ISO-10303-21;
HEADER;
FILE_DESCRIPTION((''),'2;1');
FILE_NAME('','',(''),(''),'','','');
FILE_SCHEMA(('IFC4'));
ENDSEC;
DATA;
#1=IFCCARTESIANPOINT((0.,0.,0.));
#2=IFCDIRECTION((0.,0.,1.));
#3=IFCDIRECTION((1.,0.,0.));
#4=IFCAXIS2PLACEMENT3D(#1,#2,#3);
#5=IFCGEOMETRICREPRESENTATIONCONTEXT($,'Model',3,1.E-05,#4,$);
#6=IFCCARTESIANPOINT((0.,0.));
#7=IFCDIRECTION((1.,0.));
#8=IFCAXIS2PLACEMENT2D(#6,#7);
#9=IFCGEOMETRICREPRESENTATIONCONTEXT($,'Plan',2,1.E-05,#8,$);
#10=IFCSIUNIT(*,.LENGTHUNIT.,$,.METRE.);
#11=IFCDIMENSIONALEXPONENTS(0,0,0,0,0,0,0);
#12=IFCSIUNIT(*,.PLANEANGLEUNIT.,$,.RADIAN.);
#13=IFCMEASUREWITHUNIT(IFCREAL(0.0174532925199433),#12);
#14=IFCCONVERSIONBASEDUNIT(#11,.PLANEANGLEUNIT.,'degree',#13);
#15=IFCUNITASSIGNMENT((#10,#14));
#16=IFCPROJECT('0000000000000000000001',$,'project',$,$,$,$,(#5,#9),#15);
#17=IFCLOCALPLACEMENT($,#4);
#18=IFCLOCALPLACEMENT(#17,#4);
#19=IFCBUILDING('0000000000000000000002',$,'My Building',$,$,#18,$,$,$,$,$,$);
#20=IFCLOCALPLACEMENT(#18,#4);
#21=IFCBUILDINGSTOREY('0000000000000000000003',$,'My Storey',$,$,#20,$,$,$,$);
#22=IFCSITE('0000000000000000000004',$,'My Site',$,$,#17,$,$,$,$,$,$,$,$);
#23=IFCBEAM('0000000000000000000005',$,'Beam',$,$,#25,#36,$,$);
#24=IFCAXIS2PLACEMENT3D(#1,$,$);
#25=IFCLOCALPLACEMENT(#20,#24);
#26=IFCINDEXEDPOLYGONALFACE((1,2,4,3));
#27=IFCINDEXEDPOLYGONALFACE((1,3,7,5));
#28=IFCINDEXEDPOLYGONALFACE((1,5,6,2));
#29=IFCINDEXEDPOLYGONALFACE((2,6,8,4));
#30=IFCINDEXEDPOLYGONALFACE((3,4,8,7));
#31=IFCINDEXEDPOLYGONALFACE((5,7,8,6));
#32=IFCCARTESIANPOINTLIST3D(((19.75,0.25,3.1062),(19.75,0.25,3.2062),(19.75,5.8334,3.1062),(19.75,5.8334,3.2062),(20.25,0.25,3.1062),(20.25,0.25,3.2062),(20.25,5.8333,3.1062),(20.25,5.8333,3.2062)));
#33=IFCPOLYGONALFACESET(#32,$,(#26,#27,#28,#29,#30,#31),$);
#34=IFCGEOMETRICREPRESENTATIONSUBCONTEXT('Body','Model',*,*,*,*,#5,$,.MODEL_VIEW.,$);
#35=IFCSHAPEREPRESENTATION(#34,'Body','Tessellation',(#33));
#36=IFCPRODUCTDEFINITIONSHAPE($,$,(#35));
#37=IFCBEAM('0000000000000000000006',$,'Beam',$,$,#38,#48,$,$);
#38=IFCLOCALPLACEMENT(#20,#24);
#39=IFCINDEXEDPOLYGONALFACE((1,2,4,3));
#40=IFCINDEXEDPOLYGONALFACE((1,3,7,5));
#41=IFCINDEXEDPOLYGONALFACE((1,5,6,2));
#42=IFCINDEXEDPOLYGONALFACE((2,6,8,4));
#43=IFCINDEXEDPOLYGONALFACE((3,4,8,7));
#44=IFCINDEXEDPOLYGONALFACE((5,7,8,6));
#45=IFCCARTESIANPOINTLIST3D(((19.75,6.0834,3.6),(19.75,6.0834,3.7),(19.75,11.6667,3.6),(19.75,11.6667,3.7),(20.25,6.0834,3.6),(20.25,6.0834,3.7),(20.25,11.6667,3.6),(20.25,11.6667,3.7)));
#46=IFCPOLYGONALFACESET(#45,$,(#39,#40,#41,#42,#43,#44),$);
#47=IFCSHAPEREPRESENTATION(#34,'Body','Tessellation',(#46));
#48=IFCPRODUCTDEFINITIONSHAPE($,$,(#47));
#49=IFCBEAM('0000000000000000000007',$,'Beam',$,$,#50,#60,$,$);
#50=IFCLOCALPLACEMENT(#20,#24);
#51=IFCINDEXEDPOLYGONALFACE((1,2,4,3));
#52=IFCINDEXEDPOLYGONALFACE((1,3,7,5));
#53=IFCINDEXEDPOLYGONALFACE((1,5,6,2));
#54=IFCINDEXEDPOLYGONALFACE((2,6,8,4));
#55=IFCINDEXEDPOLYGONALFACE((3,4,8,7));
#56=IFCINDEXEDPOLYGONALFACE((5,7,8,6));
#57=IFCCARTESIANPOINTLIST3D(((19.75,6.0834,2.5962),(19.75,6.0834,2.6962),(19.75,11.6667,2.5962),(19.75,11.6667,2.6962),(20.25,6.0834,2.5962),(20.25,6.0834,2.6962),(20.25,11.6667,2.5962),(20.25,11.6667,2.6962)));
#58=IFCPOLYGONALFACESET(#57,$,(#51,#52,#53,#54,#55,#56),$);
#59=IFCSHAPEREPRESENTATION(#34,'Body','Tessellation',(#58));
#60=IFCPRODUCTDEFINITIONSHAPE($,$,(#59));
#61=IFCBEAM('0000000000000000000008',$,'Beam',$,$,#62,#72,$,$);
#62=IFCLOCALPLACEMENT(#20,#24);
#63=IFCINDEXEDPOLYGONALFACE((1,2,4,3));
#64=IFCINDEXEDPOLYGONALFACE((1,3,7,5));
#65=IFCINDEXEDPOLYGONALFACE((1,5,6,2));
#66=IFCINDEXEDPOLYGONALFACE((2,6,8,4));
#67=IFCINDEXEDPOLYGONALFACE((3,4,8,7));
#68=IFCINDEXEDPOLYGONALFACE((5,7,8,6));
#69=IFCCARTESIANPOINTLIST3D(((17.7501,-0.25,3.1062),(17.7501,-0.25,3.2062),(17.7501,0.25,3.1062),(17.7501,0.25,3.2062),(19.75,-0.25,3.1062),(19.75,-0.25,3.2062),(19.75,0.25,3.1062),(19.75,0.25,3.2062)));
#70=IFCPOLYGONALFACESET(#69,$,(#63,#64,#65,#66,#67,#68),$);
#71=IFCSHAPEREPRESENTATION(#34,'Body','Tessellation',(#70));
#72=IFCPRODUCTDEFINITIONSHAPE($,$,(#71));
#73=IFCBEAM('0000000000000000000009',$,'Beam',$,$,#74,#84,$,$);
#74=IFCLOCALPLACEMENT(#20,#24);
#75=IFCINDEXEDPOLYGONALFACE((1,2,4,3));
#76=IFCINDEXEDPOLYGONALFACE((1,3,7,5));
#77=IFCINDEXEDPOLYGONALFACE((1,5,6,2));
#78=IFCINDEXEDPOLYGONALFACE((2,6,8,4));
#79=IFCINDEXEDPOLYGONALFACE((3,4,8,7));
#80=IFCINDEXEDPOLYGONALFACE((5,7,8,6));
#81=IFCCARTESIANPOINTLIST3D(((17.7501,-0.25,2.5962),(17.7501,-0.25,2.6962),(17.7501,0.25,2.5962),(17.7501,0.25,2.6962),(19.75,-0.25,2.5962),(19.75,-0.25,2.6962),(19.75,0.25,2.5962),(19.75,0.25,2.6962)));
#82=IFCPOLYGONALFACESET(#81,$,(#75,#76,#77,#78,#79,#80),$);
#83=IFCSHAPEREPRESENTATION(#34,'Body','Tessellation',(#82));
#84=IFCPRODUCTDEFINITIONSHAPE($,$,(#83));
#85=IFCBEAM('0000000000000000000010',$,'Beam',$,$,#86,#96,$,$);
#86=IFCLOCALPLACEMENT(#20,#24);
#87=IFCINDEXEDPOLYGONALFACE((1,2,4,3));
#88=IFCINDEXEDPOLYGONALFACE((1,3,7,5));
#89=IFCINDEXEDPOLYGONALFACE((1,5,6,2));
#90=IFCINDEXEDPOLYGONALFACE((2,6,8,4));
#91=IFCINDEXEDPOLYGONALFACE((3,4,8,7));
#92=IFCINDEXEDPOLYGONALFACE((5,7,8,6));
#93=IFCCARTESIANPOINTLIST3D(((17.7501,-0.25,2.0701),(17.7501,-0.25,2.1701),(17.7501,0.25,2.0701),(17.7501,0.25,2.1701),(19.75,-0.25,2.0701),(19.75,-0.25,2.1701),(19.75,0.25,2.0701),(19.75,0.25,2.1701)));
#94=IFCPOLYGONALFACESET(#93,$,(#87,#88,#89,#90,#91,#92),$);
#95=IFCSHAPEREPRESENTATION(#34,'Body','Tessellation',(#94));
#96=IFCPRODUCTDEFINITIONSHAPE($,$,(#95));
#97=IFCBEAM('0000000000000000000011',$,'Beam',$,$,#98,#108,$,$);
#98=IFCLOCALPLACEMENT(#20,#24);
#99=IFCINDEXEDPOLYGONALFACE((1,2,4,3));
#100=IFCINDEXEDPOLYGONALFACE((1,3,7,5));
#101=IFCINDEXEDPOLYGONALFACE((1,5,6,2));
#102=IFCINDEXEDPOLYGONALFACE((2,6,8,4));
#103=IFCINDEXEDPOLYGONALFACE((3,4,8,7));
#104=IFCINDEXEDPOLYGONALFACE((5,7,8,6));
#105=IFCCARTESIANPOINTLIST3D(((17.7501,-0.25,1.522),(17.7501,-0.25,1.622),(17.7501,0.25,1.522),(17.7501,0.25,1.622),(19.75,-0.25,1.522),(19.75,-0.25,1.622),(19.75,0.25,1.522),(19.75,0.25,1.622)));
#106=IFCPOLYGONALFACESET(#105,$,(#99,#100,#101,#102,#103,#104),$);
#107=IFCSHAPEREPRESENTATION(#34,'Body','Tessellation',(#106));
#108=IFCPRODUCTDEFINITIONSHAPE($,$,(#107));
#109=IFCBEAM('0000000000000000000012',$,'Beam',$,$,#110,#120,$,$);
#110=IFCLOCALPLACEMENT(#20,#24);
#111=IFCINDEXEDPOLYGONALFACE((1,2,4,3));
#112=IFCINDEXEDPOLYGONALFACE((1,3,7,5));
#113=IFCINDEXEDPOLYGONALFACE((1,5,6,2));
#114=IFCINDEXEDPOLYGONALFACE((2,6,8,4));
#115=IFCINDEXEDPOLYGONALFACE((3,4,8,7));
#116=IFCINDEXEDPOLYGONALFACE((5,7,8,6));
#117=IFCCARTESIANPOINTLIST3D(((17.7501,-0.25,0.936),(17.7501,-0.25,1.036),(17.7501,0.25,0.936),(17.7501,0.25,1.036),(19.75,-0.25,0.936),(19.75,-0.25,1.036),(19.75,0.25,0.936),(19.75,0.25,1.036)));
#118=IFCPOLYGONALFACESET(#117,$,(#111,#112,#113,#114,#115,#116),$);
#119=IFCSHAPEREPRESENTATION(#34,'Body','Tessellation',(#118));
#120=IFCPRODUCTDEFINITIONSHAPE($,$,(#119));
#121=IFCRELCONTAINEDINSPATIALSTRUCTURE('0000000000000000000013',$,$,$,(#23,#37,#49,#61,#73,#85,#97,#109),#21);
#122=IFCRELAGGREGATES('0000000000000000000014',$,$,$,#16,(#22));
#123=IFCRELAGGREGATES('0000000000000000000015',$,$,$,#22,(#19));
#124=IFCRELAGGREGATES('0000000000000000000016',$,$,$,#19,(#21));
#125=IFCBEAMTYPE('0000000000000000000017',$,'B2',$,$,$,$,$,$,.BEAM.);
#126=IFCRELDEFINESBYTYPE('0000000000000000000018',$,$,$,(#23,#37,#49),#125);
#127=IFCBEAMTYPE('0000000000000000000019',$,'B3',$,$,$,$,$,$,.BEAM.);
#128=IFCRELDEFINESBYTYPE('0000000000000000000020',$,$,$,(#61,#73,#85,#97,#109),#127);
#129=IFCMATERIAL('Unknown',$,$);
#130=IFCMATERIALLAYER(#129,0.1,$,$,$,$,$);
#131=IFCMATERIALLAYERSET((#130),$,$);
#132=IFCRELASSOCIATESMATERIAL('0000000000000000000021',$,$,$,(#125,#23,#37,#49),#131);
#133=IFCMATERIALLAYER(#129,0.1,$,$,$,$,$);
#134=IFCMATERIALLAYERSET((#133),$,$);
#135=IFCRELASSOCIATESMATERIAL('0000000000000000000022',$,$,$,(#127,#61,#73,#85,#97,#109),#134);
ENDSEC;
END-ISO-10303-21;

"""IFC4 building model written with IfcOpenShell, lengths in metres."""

from ifc_helpers import new_model, entity, si_unit, converted_unit, frame, origin_with_axes, origin_2d_with_axis, place, context, subcontext, project, spatial, indexed_curve, outline, extrude, material, layer, layer_set, layer_usage, type_object, element, save


model = new_model("IFC4")

# Units and contexts
model_context = context("Model", 3, precision=1e-05, world=origin_with_axes())
plan_context = context("Plan", 2, precision=1e-05, world=origin_2d_with_axis())
body_context = subcontext(model_context, "Body", "Model", "MODEL_VIEW")
ifc_project = project(units=[si_unit("LENGTHUNIT", "METRE"), converted_unit("PLANEANGLEUNIT", "degree", entity("IfcReal", 0.0174532925199433), si_unit("PLANEANGLEUNIT", "RADIAN"), dimensions=[0, 0, 0, 0, 0, 0, 0])], contexts=[model_context, plan_context])

# Site, building, storey
site_placement = place(None, origin_with_axes())
site = spatial("IfcSite", under=ifc_project, at=site_placement, Name="My Site")
building_placement = place(site_placement, origin_with_axes())
building = spatial("IfcBuilding", under=site, at=building_placement, Name="My Building")
storey_placement = place(building_placement, origin_with_axes())
storey = spatial("IfcBuildingStorey", under=building, at=storey_placement, Name="My Storey")

# Shared definitions
ifc_material = material(Name="Unknown")

# Beams
ifc_layer_1 = layer(ifc_material, 0.1)
ifc_layer_set_1 = layer_set([ifc_layer_1])
beam_type_1 = type_object("IfcBeamType", Name="B2", PredefinedType="BEAM", material=ifc_layer_set_1)
ifc_layer_usage_1 = layer_usage(ifc_layer_set_1, "AXIS3", "POSITIVE", -0.1)
beam_1_placement = place(storey_placement, frame((19.75, 0.25, 3.2062), z_axis=(0.0, 0.0, 1.0), x_axis=(0.0, 1.0, 0.0)))
element("IfcBeam", 1, at=beam_1_placement, inside=storey, type_object=beam_type_1, material=ifc_layer_usage_1, Name="Beam", context=body_context, shape_type="SweptSolid", body=[
    extrude(outline(indexed_curve([(0.0, 0.0), (0.0, -0.5), (5.5833, -0.5), (5.5834, 0.0), (0.0, 0.0)])), frame((0.0, 0.0, -0.1), z_axis=(0.0, 0.0, 1.0), x_axis=(1.0, 0.0, 0.0)), (0.0, 0.0, 1.0), 0.1),
])
ifc_layer_usage_2 = layer_usage(ifc_layer_set_1, "AXIS3", "POSITIVE", -0.1)
beam_2_placement = place(storey_placement, frame((19.75, 6.0834, 3.7), z_axis=(0.0, 0.0, 1.0), x_axis=(0.0, 1.0, 0.0)))
element("IfcBeam", 2, at=beam_2_placement, inside=storey, type_object=beam_type_1, material=ifc_layer_usage_2, Name="Beam", context=body_context, shape_type="SweptSolid", body=[
    extrude(outline(indexed_curve([(0.0, 0.0), (0.0, -0.5), (5.5833, -0.5), (5.5834, 0.0), (0.0, 0.0)])), frame((0.0, 0.0, -0.1), z_axis=(0.0, 0.0, 1.0), x_axis=(1.0, 0.0, 0.0)), (0.0, 0.0, 1.0), 0.1),
])
ifc_layer_usage_3 = layer_usage(ifc_layer_set_1, "AXIS3", "POSITIVE", -0.1)
beam_3_placement = place(storey_placement, frame((19.75, 6.0834, 2.6962), z_axis=(0.0, 0.0, 1.0), x_axis=(0.0, 1.0, 0.0)))
element("IfcBeam", 3, at=beam_3_placement, inside=storey, type_object=beam_type_1, material=ifc_layer_usage_3, Name="Beam", context=body_context, shape_type="SweptSolid", body=[
    extrude(outline(indexed_curve([(0.0, 0.0), (0.0, -0.5), (5.5833, -0.5), (5.5834, 0.0), (0.0, 0.0)])), frame((0.0, 0.0, -0.1), z_axis=(0.0, 0.0, 1.0), x_axis=(1.0, 0.0, 0.0)), (0.0, 0.0, 1.0), 0.1),
])
ifc_layer_2 = layer(ifc_material, 0.1)
ifc_layer_set_2 = layer_set([ifc_layer_2])
ifc_layer_usage_4 = layer_usage(ifc_layer_set_2, "AXIS3", "POSITIVE", -0.1)
beam_type_2 = type_object("IfcBeamType", Name="B3", PredefinedType="BEAM", material=ifc_layer_set_2)
beam_4_placement = place(storey_placement, frame((17.7501, -0.25, 3.2062), z_axis=(0.0, 0.0, 1.0), x_axis=(1.0, 0.0, 0.0)))
element("IfcBeam", 4, at=beam_4_placement, inside=storey, type_object=beam_type_2, material=ifc_layer_usage_4, Name="Beam", context=body_context, shape_type="SweptSolid", body=[
    extrude(outline(indexed_curve([(0.0, 0.0), (0.0, 0.5), (1.9999, 0.5), (1.9999, 0.0), (0.0, 0.0)])), frame((0.0, 0.0, -0.1), z_axis=(0.0, 0.0, 1.0), x_axis=(1.0, 0.0, 0.0)), (0.0, 0.0, 1.0), 0.1),
])
ifc_layer_usage_5 = layer_usage(ifc_layer_set_2, "AXIS3", "POSITIVE", -0.1)
beam_5_placement = place(storey_placement, frame((17.7501, -0.25, 2.6962), z_axis=(0.0, 0.0, 1.0), x_axis=(1.0, 0.0, 0.0)))
element("IfcBeam", 5, at=beam_5_placement, inside=storey, type_object=beam_type_2, material=ifc_layer_usage_5, Name="Beam", context=body_context, shape_type="SweptSolid", body=[
    extrude(outline(indexed_curve([(0.0, 0.0), (0.0, 0.5), (1.9999, 0.5), (1.9999, 0.0), (0.0, 0.0)])), frame((0.0, 0.0, -0.1), z_axis=(0.0, 0.0, 1.0), x_axis=(1.0, 0.0, 0.0)), (0.0, 0.0, 1.0), 0.1),
])
ifc_layer_usage_6 = layer_usage(ifc_layer_set_2, "AXIS3", "POSITIVE", -0.1)
beam_6_placement = place(storey_placement, frame((17.7501, -0.25, 2.1701), z_axis=(0.0, 0.0, 1.0), x_axis=(1.0, 0.0, 0.0)))
element("IfcBeam", 6, at=beam_6_placement, inside=storey, type_object=beam_type_2, material=ifc_layer_usage_6, Name="Beam", context=body_context, shape_type="SweptSolid", body=[
    extrude(outline(indexed_curve([(0.0, 0.0), (0.0, 0.5), (1.9999, 0.5), (1.9999, 0.0), (0.0, 0.0)])), frame((0.0, 0.0, -0.1), z_axis=(0.0, 0.0, 1.0), x_axis=(1.0, 0.0, 0.0)), (0.0, 0.0, 1.0), 0.1),
])
ifc_layer_usage_7 = layer_usage(ifc_layer_set_2, "AXIS3", "POSITIVE", -0.1)
beam_7_placement = place(storey_placement, frame((17.7501, -0.25, 1.622), z_axis=(0.0, 0.0, 1.0), x_axis=(1.0, 0.0, 0.0)))
element("IfcBeam", 7, at=beam_7_placement, inside=storey, type_object=beam_type_2, material=ifc_layer_usage_7, Name="Beam", context=body_context, shape_type="SweptSolid", body=[
    extrude(outline(indexed_curve([(0.0, 0.0), (0.0, 0.5), (1.9999, 0.5), (1.9999, 0.0), (0.0, 0.0)])), frame((0.0, 0.0, -0.1), z_axis=(0.0, 0.0, 1.0), x_axis=(1.0, 0.0, 0.0)), (0.0, 0.0, 1.0), 0.1),
])
ifc_layer_usage_8 = layer_usage(ifc_layer_set_2, "AXIS3", "POSITIVE", -0.1)
beam_8_placement = place(storey_placement, frame((17.7501, -0.25, 1.036), z_axis=(0.0, 0.0, 1.0), x_axis=(1.0, 0.0, 0.0)))
element("IfcBeam", 8, at=beam_8_placement, inside=storey, type_object=beam_type_2, material=ifc_layer_usage_8, Name="Beam", context=body_context, shape_type="SweptSolid", body=[
    extrude(outline(indexed_curve([(0.0, 0.0), (0.0, 0.5), (1.9999, 0.5), (1.9999, 0.0), (0.0, 0.0)])), frame((0.0, 0.0, -0.1), z_axis=(0.0, 0.0, 1.0), x_axis=(1.0, 0.0, 0.0)), (0.0, 0.0, 1.0), 0.1),
])

save(model, "model.ifc")
